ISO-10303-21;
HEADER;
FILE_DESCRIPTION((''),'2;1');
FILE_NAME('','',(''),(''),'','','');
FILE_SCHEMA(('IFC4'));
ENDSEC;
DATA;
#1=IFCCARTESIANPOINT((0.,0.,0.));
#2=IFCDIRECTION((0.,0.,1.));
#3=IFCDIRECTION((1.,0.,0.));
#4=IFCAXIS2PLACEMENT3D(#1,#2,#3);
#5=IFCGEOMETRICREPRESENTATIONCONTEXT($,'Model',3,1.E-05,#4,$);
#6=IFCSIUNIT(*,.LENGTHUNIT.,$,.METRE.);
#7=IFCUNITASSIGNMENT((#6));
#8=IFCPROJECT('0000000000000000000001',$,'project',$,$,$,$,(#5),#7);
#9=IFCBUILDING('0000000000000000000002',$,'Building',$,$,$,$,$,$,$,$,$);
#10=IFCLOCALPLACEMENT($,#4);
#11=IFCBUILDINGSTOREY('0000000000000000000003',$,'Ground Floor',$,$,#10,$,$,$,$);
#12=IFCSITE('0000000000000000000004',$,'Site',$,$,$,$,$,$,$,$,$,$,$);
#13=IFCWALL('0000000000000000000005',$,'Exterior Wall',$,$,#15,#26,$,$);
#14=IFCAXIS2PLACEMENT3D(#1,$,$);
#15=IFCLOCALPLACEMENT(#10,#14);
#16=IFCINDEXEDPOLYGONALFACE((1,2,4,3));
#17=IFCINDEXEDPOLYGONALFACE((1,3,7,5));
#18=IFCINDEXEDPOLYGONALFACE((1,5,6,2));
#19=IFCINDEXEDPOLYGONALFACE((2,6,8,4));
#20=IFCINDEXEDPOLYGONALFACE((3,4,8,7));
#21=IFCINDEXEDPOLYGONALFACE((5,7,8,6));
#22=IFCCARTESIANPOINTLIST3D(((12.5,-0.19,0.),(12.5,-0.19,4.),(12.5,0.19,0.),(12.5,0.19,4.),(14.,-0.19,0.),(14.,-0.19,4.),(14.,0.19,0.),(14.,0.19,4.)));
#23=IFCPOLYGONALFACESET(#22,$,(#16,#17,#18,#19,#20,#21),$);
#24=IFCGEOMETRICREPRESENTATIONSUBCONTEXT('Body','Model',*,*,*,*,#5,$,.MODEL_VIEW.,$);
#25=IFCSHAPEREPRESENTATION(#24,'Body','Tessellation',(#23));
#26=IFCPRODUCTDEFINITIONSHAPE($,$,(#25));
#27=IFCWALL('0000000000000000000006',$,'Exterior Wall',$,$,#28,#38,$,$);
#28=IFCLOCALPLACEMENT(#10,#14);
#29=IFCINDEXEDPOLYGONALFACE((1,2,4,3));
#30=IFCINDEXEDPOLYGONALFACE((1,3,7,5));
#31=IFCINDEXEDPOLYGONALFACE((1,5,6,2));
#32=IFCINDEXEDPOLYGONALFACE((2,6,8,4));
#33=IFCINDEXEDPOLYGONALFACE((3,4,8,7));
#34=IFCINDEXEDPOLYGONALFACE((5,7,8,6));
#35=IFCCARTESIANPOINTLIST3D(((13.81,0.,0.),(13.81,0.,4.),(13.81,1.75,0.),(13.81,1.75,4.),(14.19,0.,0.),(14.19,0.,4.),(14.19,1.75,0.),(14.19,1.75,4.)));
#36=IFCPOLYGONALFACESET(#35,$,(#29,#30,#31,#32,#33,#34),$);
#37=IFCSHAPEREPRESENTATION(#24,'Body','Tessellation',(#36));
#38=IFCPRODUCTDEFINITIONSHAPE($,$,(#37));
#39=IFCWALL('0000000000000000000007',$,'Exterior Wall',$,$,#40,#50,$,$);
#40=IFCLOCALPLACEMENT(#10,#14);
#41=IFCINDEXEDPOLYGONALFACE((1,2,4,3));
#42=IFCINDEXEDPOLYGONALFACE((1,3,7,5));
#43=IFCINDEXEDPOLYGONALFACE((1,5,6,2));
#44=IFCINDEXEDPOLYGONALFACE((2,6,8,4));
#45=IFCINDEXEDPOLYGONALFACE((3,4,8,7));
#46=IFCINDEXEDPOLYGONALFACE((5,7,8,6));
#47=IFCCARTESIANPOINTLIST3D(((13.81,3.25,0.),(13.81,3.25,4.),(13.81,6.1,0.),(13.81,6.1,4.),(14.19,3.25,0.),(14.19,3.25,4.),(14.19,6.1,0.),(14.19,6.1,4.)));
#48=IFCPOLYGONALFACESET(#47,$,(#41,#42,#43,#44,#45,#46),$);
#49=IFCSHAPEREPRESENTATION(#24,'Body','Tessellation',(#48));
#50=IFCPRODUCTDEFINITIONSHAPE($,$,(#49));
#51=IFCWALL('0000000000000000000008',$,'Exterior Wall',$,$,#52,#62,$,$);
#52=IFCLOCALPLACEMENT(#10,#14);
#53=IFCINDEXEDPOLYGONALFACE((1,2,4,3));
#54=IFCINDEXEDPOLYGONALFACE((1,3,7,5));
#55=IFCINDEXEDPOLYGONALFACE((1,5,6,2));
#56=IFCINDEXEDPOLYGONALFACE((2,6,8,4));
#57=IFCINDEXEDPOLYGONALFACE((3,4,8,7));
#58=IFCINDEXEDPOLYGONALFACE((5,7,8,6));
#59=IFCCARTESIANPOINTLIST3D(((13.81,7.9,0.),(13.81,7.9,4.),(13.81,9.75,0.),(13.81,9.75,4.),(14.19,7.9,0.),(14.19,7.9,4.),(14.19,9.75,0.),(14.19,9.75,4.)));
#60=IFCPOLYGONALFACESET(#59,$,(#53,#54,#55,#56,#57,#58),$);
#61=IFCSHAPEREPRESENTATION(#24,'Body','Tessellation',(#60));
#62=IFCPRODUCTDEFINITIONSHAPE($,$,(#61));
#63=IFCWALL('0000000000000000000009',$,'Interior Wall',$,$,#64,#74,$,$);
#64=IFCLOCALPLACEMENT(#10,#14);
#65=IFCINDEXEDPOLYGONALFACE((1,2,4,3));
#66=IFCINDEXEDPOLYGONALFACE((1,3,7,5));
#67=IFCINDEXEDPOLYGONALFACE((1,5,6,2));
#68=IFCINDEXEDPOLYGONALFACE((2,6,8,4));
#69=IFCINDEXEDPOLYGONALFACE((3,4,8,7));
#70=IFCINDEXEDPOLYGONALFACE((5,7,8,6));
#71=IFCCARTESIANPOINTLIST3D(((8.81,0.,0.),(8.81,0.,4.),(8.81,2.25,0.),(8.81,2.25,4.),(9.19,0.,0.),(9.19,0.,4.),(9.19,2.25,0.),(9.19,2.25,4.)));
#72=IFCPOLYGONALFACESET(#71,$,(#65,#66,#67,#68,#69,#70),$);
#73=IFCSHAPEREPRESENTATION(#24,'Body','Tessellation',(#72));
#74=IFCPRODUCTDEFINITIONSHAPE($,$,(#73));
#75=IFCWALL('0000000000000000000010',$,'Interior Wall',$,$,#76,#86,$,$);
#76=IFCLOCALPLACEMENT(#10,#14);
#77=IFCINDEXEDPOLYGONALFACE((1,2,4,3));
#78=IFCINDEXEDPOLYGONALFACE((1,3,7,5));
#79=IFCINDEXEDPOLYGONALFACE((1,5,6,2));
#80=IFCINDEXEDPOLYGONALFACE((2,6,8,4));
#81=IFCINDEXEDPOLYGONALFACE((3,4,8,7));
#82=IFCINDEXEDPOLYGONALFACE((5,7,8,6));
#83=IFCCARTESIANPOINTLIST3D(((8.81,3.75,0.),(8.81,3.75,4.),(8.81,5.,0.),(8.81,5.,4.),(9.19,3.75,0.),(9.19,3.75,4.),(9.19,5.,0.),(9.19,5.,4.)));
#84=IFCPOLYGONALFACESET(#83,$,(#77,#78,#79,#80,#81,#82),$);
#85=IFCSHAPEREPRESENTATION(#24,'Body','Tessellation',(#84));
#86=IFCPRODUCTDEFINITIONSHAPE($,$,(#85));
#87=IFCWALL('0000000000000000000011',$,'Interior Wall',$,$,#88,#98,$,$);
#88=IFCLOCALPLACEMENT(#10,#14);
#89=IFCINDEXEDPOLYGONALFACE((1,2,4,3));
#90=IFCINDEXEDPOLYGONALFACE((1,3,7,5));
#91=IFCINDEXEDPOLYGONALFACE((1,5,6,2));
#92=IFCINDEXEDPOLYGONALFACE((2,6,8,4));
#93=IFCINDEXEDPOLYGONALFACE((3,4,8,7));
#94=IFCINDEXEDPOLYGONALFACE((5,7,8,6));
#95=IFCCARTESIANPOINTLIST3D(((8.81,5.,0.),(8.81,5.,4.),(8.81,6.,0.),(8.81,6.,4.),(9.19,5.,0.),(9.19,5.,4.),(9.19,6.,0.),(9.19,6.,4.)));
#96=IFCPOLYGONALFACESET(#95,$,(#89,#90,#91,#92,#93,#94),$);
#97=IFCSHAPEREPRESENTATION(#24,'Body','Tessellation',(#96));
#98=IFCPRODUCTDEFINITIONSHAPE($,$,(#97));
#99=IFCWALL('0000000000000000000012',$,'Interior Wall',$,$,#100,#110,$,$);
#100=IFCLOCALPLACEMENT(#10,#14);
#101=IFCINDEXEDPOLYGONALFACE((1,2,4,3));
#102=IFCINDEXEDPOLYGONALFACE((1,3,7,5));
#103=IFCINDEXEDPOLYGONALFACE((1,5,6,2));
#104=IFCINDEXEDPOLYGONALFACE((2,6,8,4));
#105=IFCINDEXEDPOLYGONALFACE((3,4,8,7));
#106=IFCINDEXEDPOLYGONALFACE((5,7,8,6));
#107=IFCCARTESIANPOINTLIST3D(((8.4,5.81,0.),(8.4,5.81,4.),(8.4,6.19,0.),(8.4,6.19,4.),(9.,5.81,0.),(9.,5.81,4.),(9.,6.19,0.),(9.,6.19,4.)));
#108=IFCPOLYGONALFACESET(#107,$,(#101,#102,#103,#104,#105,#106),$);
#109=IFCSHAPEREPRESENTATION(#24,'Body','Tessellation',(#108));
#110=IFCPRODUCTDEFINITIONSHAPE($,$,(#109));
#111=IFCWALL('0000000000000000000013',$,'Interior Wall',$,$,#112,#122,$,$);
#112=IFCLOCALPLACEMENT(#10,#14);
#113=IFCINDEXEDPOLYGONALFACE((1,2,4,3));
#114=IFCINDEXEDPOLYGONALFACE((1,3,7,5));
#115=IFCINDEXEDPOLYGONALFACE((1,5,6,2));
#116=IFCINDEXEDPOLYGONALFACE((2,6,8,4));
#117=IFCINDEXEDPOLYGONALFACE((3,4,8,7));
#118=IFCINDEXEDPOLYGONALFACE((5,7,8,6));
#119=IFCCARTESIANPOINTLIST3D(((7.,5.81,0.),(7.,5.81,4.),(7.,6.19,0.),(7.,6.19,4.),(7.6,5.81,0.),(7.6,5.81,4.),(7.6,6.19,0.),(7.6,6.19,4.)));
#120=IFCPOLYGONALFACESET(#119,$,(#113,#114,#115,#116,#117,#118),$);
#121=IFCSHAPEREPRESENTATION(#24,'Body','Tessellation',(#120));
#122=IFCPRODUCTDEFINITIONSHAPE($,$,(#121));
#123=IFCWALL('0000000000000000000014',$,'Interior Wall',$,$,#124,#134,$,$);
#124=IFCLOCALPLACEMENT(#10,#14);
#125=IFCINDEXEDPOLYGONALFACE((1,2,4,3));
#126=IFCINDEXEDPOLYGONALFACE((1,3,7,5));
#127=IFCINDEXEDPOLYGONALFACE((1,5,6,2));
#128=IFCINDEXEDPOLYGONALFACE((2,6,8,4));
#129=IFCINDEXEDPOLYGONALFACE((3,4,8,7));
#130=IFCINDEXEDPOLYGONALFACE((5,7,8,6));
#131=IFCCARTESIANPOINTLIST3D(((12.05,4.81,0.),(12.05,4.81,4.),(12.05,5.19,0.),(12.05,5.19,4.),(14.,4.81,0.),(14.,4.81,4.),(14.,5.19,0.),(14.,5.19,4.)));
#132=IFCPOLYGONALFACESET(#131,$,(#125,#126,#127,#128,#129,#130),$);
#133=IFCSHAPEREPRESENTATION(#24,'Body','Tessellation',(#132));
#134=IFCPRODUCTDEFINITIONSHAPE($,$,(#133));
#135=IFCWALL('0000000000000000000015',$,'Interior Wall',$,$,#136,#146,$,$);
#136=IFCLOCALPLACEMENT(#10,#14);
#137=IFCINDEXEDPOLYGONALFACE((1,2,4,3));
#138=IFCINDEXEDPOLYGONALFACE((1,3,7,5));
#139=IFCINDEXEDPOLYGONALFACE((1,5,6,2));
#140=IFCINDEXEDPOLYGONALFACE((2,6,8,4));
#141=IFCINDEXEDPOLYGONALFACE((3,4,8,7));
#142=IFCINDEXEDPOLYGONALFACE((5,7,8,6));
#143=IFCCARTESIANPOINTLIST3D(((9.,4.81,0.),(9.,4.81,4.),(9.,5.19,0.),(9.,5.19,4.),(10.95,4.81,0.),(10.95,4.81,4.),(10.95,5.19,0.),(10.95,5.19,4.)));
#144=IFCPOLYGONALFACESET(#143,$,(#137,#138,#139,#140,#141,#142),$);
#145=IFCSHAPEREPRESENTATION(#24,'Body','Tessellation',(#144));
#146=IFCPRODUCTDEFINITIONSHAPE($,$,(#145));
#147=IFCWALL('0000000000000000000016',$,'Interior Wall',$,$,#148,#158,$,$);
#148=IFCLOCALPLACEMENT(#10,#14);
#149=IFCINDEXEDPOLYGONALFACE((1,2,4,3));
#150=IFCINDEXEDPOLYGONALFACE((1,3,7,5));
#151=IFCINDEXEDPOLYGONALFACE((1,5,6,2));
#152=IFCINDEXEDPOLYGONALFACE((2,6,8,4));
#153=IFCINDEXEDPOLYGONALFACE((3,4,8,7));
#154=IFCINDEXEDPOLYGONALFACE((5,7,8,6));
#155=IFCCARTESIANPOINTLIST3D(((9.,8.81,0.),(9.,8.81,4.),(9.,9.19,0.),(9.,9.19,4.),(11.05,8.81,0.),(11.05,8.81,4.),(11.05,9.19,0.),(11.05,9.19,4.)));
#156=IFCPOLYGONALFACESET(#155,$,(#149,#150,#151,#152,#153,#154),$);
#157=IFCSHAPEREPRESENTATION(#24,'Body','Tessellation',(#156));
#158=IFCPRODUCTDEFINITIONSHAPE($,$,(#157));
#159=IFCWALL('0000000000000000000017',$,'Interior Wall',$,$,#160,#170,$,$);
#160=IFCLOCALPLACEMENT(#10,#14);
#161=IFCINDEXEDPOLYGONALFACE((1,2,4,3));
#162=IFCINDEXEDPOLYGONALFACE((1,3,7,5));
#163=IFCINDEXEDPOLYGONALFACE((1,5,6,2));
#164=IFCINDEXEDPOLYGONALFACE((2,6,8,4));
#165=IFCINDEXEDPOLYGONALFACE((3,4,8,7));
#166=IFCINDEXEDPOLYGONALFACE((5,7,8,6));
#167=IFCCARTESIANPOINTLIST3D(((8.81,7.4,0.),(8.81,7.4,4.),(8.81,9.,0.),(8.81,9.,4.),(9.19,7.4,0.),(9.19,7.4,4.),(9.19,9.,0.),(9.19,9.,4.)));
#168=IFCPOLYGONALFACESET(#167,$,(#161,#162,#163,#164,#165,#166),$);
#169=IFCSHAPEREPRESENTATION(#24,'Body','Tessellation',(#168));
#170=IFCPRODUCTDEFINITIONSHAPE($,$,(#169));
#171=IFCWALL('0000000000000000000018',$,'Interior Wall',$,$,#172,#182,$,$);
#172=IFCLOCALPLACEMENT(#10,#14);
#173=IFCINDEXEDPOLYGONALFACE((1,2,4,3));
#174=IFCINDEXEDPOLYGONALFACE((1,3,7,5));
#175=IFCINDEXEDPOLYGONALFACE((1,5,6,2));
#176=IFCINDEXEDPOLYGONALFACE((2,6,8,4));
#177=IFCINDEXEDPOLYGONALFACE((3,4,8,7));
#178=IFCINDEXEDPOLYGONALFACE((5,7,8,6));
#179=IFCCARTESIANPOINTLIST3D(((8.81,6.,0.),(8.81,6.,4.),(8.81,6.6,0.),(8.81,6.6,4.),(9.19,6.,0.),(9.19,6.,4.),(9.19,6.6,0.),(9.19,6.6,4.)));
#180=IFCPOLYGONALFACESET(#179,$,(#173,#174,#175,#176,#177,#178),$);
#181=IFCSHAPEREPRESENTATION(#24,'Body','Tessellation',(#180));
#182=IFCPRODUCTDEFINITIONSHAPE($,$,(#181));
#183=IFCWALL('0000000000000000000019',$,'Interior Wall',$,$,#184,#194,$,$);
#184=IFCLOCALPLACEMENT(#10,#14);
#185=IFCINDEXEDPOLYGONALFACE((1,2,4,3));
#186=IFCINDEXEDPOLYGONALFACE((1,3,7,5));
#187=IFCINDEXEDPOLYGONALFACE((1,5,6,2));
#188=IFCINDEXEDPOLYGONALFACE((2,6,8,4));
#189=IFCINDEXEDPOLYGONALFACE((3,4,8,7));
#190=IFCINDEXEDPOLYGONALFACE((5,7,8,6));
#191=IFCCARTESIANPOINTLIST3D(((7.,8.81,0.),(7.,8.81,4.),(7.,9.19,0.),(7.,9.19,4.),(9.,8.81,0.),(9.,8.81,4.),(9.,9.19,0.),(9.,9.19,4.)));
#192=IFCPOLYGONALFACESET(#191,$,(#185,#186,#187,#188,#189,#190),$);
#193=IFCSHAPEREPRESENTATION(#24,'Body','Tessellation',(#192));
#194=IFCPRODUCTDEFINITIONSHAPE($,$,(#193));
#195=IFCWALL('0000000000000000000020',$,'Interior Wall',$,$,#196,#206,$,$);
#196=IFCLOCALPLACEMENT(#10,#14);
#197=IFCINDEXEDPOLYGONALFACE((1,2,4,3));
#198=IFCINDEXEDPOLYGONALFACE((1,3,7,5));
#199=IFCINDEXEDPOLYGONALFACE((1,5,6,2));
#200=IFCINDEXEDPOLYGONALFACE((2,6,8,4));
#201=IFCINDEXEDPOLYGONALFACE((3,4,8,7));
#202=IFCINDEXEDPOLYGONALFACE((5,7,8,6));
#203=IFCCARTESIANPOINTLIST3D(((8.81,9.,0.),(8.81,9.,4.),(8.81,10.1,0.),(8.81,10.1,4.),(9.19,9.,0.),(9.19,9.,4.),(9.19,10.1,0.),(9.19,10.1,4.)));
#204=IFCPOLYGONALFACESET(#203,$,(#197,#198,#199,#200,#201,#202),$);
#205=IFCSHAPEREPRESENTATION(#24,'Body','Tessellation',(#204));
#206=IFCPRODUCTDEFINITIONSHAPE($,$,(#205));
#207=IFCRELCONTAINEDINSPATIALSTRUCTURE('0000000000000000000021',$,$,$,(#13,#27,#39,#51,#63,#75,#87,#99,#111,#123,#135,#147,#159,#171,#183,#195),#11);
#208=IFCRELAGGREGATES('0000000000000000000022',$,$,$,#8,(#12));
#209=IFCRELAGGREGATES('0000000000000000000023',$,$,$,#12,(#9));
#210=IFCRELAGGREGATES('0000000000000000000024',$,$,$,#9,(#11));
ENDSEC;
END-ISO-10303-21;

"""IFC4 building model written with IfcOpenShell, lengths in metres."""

from ifc_helpers import new_model, si_unit, frame, origin_with_axes, place, context, subcontext, project, spatial, indexed_curve, outline, extrude, element, save


model = new_model("IFC4")

# Units and contexts
model_context = context("Model", 3, precision=1e-05, world=origin_with_axes())
body_context = subcontext(model_context, "Body", "Model", "MODEL_VIEW")
ifc_project = project(units=[si_unit("LENGTHUNIT", "METRE")], contexts=[model_context])

# Site, building, storey
site = spatial("IfcSite", under=ifc_project, Name="Site")
building = spatial("IfcBuilding", under=site, Name="Building")
storey_placement = place(None, origin_with_axes())
storey = spatial("IfcBuildingStorey", under=building, at=storey_placement, Name="Ground Floor")

# Walls
wall_1_placement = place(storey_placement, frame((12.5, 0.0, 0.0), z_axis=(0.0, 0.0, 1.0), x_axis=(1.0, 0.0, 0.0)))
element("IfcWall", 1, at=wall_1_placement, inside=storey, Name="Exterior Wall", context=body_context, shape_type="SweptSolid", body=[
    extrude(outline(indexed_curve([(0.0, 0.0), (0.0, 0.38), (1.5, 0.38), (1.5, 0.0), (0.0, 0.0)], self_intersect=False)), frame((0.0, -0.19, 0.0), z_axis=(0.0, 0.0, 1.0), x_axis=(1.0, 0.0, 0.0)), (0.0, 0.0, 1.0), 4.0),
])
wall_2_placement = place(storey_placement, frame((14.0, 0.0, 0.0), z_axis=(0.0, 0.0, 1.0), x_axis=(0.0, 1.0, 0.0)))
element("IfcWall", 2, at=wall_2_placement, inside=storey, Name="Exterior Wall", context=body_context, shape_type="SweptSolid", body=[
    extrude(outline(indexed_curve([(0.0, 0.0), (0.0, 0.38), (1.75, 0.38), (1.75, 0.0), (0.0, 0.0)], self_intersect=False)), frame((0.0, -0.19, 0.0), z_axis=(0.0, 0.0, 1.0), x_axis=(1.0, 0.0, 0.0)), (0.0, 0.0, 1.0), 4.0),
])
wall_3_placement = place(storey_placement, frame((14.0, 3.25, 0.0), z_axis=(0.0, 0.0, 1.0), x_axis=(0.0, 1.0, 0.0)))
element("IfcWall", 3, at=wall_3_placement, inside=storey, Name="Exterior Wall", context=body_context, shape_type="SweptSolid", body=[
    extrude(outline(indexed_curve([(0.0, 0.0), (0.0, 0.38), (2.85, 0.38), (2.85, 0.0), (0.0, 0.0)], self_intersect=False)), frame((0.0, -0.19, 0.0), z_axis=(0.0, 0.0, 1.0), x_axis=(1.0, 0.0, 0.0)), (0.0, 0.0, 1.0), 4.0),
])
wall_4_placement = place(storey_placement, frame((14.0, 7.9, 0.0), z_axis=(0.0, 0.0, 1.0), x_axis=(0.0, 1.0, 0.0)))
element("IfcWall", 4, at=wall_4_placement, inside=storey, Name="Exterior Wall", context=body_context, shape_type="SweptSolid", body=[
    extrude(outline(indexed_curve([(0.0, 0.0), (0.0, 0.38), (1.85, 0.38), (1.85, 0.0), (0.0, 0.0)], self_intersect=False)), frame((0.0, -0.19, 0.0), z_axis=(0.0, 0.0, 1.0), x_axis=(1.0, 0.0, 0.0)), (0.0, 0.0, 1.0), 4.0),
])
wall_5_placement = place(storey_placement, frame((9.0, 0.0, 0.0), z_axis=(0.0, 0.0, 1.0), x_axis=(0.0, 1.0, 0.0)))
element("IfcWall", 5, at=wall_5_placement, inside=storey, Name="Interior Wall", context=body_context, shape_type="SweptSolid", body=[
    extrude(outline(indexed_curve([(0.0, 0.0), (0.0, 0.38), (2.25, 0.38), (2.25, 0.0), (0.0, 0.0)], self_intersect=False)), frame((0.0, -0.19, 0.0), z_axis=(0.0, 0.0, 1.0), x_axis=(1.0, 0.0, 0.0)), (0.0, 0.0, 1.0), 4.0),
])
wall_6_placement = place(storey_placement, frame((9.0, 3.75, 0.0), z_axis=(0.0, 0.0, 1.0), x_axis=(0.0, 1.0, 0.0)))
element("IfcWall", 6, at=wall_6_placement, inside=storey, Name="Interior Wall", context=body_context, shape_type="SweptSolid", body=[
    extrude(outline(indexed_curve([(0.0, 0.0), (0.0, 0.38), (1.25, 0.38), (1.25, 0.0), (0.0, 0.0)], self_intersect=False)), frame((0.0, -0.19, 0.0), z_axis=(0.0, 0.0, 1.0), x_axis=(1.0, 0.0, 0.0)), (0.0, 0.0, 1.0), 4.0),
])
wall_7_placement = place(storey_placement, frame((9.0, 5.0, 0.0), z_axis=(0.0, 0.0, 1.0), x_axis=(0.0, 1.0, 0.0)))
element("IfcWall", 7, at=wall_7_placement, inside=storey, Name="Interior Wall", context=body_context, shape_type="SweptSolid", body=[
    extrude(outline(indexed_curve([(0.0, 0.0), (0.0, 0.38), (1.0, 0.38), (1.0, 0.0), (0.0, 0.0)], self_intersect=False)), frame((0.0, -0.19, 0.0), z_axis=(0.0, 0.0, 1.0), x_axis=(1.0, 0.0, 0.0)), (0.0, 0.0, 1.0), 4.0),
])
for number, where, z_axis, x_axis, name in (
    (8, (9.0, 6.0, 0.0), (0.0, 0.0, 1.0), (-1.0, 0.0, 0.0), "Interior Wall"),
    (9, (7.6, 6.0, 0.0), (0.0, 0.0, 1.0), (-1.0, 0.0, 0.0), "Interior Wall"),
):
    element("IfcWall", number, at=place(storey_placement, frame(where, z_axis=z_axis, x_axis=x_axis)), inside=storey, Name=name, context=body_context, shape_type="SweptSolid", body=[
        extrude(outline(indexed_curve([(0.0, 0.0), (0.0, 0.38), (0.6, 0.38), (0.6, 0.0), (0.0, 0.0)], self_intersect=False)), frame((0.0, -0.19, 0.0), z_axis=(0.0, 0.0, 1.0), x_axis=(1.0, 0.0, 0.0)), (0.0, 0.0, 1.0), 4.0),
    ])
for number, where, z_axis, x_axis, name in (
    (10, (14.0, 5.0, 0.0), (0.0, 0.0, 1.0), (-1.0, 0.0, 0.0), "Interior Wall"),
    (11, (10.95, 5.0, 0.0), (0.0, 0.0, 1.0), (-1.0, 0.0, 0.0), "Interior Wall"),
):
    element("IfcWall", number, at=place(storey_placement, frame(where, z_axis=z_axis, x_axis=x_axis)), inside=storey, Name=name, context=body_context, shape_type="SweptSolid", body=[
        extrude(outline(indexed_curve([(0.0, 0.0), (0.0, 0.38), (1.95, 0.38), (1.95, 0.0), (0.0, 0.0)], self_intersect=False)), frame((0.0, -0.19, 0.0), z_axis=(0.0, 0.0, 1.0), x_axis=(1.0, 0.0, 0.0)), (0.0, 0.0, 1.0), 4.0),
    ])
wall_8_placement = place(storey_placement, frame((11.05, 9.0, 0.0), z_axis=(0.0, 0.0, 1.0), x_axis=(-1.0, 0.0, 0.0)))
element("IfcWall", 12, at=wall_8_placement, inside=storey, Name="Interior Wall", context=body_context, shape_type="SweptSolid", body=[
    extrude(outline(indexed_curve([(0.0, 0.0), (0.0, 0.38), (2.05, 0.38), (2.05, 0.0), (0.0, 0.0)], self_intersect=False)), frame((0.0, -0.19, 0.0), z_axis=(0.0, 0.0, 1.0), x_axis=(1.0, 0.0, 0.0)), (0.0, 0.0, 1.0), 4.0),
])
wall_9_placement = place(storey_placement, frame((9.0, 9.0, 0.0), z_axis=(0.0, 0.0, 1.0), x_axis=(0.0, -1.0, 0.0)))
element("IfcWall", 13, at=wall_9_placement, inside=storey, Name="Interior Wall", context=body_context, shape_type="SweptSolid", body=[
    extrude(outline(indexed_curve([(0.0, 0.0), (0.0, 0.38), (1.6, 0.38), (1.6, 0.0), (0.0, 0.0)], self_intersect=False)), frame((0.0, -0.19, 0.0), z_axis=(0.0, 0.0, 1.0), x_axis=(1.0, 0.0, 0.0)), (0.0, 0.0, 1.0), 4.0),
])
wall_10_placement = place(storey_placement, frame((9.0, 6.6, 0.0), z_axis=(0.0, 0.0, 1.0), x_axis=(0.0, -1.0, 0.0)))
element("IfcWall", 14, at=wall_10_placement, inside=storey, Name="Interior Wall", context=body_context, shape_type="SweptSolid", body=[
    extrude(outline(indexed_curve([(0.0, 0.0), (0.0, 0.38), (0.6, 0.38), (0.6, 0.0), (0.0, 0.0)], self_intersect=False)), frame((0.0, -0.19, 0.0), z_axis=(0.0, 0.0, 1.0), x_axis=(1.0, 0.0, 0.0)), (0.0, 0.0, 1.0), 4.0),
])
wall_11_placement = place(storey_placement, frame((9.0, 9.0, 0.0), z_axis=(0.0, 0.0, 1.0), x_axis=(-1.0, 0.0, 0.0)))
element("IfcWall", 15, at=wall_11_placement, inside=storey, Name="Interior Wall", context=body_context, shape_type="SweptSolid", body=[
    extrude(outline(indexed_curve([(0.0, 0.0), (0.0, 0.38), (2.0, 0.38), (2.0, 0.0), (0.0, 0.0)], self_intersect=False)), frame((0.0, -0.19, 0.0), z_axis=(0.0, 0.0, 1.0), x_axis=(1.0, 0.0, 0.0)), (0.0, 0.0, 1.0), 4.0),
])
wall_12_placement = place(storey_placement, frame((9.0, 9.0, 0.0), z_axis=(0.0, 0.0, 1.0), x_axis=(0.0, 1.0, 0.0)))
element("IfcWall", 16, at=wall_12_placement, inside=storey, Name="Interior Wall", context=body_context, shape_type="SweptSolid", body=[
    extrude(outline(indexed_curve([(0.0, 0.0), (0.0, 0.38), (1.1, 0.38), (1.1, 0.0), (0.0, 0.0)], self_intersect=False)), frame((0.0, -0.19, 0.0), z_axis=(0.0, 0.0, 1.0), x_axis=(1.0, 0.0, 0.0)), (0.0, 0.0, 1.0), 4.0),
])

save(model, "model.ifc")
